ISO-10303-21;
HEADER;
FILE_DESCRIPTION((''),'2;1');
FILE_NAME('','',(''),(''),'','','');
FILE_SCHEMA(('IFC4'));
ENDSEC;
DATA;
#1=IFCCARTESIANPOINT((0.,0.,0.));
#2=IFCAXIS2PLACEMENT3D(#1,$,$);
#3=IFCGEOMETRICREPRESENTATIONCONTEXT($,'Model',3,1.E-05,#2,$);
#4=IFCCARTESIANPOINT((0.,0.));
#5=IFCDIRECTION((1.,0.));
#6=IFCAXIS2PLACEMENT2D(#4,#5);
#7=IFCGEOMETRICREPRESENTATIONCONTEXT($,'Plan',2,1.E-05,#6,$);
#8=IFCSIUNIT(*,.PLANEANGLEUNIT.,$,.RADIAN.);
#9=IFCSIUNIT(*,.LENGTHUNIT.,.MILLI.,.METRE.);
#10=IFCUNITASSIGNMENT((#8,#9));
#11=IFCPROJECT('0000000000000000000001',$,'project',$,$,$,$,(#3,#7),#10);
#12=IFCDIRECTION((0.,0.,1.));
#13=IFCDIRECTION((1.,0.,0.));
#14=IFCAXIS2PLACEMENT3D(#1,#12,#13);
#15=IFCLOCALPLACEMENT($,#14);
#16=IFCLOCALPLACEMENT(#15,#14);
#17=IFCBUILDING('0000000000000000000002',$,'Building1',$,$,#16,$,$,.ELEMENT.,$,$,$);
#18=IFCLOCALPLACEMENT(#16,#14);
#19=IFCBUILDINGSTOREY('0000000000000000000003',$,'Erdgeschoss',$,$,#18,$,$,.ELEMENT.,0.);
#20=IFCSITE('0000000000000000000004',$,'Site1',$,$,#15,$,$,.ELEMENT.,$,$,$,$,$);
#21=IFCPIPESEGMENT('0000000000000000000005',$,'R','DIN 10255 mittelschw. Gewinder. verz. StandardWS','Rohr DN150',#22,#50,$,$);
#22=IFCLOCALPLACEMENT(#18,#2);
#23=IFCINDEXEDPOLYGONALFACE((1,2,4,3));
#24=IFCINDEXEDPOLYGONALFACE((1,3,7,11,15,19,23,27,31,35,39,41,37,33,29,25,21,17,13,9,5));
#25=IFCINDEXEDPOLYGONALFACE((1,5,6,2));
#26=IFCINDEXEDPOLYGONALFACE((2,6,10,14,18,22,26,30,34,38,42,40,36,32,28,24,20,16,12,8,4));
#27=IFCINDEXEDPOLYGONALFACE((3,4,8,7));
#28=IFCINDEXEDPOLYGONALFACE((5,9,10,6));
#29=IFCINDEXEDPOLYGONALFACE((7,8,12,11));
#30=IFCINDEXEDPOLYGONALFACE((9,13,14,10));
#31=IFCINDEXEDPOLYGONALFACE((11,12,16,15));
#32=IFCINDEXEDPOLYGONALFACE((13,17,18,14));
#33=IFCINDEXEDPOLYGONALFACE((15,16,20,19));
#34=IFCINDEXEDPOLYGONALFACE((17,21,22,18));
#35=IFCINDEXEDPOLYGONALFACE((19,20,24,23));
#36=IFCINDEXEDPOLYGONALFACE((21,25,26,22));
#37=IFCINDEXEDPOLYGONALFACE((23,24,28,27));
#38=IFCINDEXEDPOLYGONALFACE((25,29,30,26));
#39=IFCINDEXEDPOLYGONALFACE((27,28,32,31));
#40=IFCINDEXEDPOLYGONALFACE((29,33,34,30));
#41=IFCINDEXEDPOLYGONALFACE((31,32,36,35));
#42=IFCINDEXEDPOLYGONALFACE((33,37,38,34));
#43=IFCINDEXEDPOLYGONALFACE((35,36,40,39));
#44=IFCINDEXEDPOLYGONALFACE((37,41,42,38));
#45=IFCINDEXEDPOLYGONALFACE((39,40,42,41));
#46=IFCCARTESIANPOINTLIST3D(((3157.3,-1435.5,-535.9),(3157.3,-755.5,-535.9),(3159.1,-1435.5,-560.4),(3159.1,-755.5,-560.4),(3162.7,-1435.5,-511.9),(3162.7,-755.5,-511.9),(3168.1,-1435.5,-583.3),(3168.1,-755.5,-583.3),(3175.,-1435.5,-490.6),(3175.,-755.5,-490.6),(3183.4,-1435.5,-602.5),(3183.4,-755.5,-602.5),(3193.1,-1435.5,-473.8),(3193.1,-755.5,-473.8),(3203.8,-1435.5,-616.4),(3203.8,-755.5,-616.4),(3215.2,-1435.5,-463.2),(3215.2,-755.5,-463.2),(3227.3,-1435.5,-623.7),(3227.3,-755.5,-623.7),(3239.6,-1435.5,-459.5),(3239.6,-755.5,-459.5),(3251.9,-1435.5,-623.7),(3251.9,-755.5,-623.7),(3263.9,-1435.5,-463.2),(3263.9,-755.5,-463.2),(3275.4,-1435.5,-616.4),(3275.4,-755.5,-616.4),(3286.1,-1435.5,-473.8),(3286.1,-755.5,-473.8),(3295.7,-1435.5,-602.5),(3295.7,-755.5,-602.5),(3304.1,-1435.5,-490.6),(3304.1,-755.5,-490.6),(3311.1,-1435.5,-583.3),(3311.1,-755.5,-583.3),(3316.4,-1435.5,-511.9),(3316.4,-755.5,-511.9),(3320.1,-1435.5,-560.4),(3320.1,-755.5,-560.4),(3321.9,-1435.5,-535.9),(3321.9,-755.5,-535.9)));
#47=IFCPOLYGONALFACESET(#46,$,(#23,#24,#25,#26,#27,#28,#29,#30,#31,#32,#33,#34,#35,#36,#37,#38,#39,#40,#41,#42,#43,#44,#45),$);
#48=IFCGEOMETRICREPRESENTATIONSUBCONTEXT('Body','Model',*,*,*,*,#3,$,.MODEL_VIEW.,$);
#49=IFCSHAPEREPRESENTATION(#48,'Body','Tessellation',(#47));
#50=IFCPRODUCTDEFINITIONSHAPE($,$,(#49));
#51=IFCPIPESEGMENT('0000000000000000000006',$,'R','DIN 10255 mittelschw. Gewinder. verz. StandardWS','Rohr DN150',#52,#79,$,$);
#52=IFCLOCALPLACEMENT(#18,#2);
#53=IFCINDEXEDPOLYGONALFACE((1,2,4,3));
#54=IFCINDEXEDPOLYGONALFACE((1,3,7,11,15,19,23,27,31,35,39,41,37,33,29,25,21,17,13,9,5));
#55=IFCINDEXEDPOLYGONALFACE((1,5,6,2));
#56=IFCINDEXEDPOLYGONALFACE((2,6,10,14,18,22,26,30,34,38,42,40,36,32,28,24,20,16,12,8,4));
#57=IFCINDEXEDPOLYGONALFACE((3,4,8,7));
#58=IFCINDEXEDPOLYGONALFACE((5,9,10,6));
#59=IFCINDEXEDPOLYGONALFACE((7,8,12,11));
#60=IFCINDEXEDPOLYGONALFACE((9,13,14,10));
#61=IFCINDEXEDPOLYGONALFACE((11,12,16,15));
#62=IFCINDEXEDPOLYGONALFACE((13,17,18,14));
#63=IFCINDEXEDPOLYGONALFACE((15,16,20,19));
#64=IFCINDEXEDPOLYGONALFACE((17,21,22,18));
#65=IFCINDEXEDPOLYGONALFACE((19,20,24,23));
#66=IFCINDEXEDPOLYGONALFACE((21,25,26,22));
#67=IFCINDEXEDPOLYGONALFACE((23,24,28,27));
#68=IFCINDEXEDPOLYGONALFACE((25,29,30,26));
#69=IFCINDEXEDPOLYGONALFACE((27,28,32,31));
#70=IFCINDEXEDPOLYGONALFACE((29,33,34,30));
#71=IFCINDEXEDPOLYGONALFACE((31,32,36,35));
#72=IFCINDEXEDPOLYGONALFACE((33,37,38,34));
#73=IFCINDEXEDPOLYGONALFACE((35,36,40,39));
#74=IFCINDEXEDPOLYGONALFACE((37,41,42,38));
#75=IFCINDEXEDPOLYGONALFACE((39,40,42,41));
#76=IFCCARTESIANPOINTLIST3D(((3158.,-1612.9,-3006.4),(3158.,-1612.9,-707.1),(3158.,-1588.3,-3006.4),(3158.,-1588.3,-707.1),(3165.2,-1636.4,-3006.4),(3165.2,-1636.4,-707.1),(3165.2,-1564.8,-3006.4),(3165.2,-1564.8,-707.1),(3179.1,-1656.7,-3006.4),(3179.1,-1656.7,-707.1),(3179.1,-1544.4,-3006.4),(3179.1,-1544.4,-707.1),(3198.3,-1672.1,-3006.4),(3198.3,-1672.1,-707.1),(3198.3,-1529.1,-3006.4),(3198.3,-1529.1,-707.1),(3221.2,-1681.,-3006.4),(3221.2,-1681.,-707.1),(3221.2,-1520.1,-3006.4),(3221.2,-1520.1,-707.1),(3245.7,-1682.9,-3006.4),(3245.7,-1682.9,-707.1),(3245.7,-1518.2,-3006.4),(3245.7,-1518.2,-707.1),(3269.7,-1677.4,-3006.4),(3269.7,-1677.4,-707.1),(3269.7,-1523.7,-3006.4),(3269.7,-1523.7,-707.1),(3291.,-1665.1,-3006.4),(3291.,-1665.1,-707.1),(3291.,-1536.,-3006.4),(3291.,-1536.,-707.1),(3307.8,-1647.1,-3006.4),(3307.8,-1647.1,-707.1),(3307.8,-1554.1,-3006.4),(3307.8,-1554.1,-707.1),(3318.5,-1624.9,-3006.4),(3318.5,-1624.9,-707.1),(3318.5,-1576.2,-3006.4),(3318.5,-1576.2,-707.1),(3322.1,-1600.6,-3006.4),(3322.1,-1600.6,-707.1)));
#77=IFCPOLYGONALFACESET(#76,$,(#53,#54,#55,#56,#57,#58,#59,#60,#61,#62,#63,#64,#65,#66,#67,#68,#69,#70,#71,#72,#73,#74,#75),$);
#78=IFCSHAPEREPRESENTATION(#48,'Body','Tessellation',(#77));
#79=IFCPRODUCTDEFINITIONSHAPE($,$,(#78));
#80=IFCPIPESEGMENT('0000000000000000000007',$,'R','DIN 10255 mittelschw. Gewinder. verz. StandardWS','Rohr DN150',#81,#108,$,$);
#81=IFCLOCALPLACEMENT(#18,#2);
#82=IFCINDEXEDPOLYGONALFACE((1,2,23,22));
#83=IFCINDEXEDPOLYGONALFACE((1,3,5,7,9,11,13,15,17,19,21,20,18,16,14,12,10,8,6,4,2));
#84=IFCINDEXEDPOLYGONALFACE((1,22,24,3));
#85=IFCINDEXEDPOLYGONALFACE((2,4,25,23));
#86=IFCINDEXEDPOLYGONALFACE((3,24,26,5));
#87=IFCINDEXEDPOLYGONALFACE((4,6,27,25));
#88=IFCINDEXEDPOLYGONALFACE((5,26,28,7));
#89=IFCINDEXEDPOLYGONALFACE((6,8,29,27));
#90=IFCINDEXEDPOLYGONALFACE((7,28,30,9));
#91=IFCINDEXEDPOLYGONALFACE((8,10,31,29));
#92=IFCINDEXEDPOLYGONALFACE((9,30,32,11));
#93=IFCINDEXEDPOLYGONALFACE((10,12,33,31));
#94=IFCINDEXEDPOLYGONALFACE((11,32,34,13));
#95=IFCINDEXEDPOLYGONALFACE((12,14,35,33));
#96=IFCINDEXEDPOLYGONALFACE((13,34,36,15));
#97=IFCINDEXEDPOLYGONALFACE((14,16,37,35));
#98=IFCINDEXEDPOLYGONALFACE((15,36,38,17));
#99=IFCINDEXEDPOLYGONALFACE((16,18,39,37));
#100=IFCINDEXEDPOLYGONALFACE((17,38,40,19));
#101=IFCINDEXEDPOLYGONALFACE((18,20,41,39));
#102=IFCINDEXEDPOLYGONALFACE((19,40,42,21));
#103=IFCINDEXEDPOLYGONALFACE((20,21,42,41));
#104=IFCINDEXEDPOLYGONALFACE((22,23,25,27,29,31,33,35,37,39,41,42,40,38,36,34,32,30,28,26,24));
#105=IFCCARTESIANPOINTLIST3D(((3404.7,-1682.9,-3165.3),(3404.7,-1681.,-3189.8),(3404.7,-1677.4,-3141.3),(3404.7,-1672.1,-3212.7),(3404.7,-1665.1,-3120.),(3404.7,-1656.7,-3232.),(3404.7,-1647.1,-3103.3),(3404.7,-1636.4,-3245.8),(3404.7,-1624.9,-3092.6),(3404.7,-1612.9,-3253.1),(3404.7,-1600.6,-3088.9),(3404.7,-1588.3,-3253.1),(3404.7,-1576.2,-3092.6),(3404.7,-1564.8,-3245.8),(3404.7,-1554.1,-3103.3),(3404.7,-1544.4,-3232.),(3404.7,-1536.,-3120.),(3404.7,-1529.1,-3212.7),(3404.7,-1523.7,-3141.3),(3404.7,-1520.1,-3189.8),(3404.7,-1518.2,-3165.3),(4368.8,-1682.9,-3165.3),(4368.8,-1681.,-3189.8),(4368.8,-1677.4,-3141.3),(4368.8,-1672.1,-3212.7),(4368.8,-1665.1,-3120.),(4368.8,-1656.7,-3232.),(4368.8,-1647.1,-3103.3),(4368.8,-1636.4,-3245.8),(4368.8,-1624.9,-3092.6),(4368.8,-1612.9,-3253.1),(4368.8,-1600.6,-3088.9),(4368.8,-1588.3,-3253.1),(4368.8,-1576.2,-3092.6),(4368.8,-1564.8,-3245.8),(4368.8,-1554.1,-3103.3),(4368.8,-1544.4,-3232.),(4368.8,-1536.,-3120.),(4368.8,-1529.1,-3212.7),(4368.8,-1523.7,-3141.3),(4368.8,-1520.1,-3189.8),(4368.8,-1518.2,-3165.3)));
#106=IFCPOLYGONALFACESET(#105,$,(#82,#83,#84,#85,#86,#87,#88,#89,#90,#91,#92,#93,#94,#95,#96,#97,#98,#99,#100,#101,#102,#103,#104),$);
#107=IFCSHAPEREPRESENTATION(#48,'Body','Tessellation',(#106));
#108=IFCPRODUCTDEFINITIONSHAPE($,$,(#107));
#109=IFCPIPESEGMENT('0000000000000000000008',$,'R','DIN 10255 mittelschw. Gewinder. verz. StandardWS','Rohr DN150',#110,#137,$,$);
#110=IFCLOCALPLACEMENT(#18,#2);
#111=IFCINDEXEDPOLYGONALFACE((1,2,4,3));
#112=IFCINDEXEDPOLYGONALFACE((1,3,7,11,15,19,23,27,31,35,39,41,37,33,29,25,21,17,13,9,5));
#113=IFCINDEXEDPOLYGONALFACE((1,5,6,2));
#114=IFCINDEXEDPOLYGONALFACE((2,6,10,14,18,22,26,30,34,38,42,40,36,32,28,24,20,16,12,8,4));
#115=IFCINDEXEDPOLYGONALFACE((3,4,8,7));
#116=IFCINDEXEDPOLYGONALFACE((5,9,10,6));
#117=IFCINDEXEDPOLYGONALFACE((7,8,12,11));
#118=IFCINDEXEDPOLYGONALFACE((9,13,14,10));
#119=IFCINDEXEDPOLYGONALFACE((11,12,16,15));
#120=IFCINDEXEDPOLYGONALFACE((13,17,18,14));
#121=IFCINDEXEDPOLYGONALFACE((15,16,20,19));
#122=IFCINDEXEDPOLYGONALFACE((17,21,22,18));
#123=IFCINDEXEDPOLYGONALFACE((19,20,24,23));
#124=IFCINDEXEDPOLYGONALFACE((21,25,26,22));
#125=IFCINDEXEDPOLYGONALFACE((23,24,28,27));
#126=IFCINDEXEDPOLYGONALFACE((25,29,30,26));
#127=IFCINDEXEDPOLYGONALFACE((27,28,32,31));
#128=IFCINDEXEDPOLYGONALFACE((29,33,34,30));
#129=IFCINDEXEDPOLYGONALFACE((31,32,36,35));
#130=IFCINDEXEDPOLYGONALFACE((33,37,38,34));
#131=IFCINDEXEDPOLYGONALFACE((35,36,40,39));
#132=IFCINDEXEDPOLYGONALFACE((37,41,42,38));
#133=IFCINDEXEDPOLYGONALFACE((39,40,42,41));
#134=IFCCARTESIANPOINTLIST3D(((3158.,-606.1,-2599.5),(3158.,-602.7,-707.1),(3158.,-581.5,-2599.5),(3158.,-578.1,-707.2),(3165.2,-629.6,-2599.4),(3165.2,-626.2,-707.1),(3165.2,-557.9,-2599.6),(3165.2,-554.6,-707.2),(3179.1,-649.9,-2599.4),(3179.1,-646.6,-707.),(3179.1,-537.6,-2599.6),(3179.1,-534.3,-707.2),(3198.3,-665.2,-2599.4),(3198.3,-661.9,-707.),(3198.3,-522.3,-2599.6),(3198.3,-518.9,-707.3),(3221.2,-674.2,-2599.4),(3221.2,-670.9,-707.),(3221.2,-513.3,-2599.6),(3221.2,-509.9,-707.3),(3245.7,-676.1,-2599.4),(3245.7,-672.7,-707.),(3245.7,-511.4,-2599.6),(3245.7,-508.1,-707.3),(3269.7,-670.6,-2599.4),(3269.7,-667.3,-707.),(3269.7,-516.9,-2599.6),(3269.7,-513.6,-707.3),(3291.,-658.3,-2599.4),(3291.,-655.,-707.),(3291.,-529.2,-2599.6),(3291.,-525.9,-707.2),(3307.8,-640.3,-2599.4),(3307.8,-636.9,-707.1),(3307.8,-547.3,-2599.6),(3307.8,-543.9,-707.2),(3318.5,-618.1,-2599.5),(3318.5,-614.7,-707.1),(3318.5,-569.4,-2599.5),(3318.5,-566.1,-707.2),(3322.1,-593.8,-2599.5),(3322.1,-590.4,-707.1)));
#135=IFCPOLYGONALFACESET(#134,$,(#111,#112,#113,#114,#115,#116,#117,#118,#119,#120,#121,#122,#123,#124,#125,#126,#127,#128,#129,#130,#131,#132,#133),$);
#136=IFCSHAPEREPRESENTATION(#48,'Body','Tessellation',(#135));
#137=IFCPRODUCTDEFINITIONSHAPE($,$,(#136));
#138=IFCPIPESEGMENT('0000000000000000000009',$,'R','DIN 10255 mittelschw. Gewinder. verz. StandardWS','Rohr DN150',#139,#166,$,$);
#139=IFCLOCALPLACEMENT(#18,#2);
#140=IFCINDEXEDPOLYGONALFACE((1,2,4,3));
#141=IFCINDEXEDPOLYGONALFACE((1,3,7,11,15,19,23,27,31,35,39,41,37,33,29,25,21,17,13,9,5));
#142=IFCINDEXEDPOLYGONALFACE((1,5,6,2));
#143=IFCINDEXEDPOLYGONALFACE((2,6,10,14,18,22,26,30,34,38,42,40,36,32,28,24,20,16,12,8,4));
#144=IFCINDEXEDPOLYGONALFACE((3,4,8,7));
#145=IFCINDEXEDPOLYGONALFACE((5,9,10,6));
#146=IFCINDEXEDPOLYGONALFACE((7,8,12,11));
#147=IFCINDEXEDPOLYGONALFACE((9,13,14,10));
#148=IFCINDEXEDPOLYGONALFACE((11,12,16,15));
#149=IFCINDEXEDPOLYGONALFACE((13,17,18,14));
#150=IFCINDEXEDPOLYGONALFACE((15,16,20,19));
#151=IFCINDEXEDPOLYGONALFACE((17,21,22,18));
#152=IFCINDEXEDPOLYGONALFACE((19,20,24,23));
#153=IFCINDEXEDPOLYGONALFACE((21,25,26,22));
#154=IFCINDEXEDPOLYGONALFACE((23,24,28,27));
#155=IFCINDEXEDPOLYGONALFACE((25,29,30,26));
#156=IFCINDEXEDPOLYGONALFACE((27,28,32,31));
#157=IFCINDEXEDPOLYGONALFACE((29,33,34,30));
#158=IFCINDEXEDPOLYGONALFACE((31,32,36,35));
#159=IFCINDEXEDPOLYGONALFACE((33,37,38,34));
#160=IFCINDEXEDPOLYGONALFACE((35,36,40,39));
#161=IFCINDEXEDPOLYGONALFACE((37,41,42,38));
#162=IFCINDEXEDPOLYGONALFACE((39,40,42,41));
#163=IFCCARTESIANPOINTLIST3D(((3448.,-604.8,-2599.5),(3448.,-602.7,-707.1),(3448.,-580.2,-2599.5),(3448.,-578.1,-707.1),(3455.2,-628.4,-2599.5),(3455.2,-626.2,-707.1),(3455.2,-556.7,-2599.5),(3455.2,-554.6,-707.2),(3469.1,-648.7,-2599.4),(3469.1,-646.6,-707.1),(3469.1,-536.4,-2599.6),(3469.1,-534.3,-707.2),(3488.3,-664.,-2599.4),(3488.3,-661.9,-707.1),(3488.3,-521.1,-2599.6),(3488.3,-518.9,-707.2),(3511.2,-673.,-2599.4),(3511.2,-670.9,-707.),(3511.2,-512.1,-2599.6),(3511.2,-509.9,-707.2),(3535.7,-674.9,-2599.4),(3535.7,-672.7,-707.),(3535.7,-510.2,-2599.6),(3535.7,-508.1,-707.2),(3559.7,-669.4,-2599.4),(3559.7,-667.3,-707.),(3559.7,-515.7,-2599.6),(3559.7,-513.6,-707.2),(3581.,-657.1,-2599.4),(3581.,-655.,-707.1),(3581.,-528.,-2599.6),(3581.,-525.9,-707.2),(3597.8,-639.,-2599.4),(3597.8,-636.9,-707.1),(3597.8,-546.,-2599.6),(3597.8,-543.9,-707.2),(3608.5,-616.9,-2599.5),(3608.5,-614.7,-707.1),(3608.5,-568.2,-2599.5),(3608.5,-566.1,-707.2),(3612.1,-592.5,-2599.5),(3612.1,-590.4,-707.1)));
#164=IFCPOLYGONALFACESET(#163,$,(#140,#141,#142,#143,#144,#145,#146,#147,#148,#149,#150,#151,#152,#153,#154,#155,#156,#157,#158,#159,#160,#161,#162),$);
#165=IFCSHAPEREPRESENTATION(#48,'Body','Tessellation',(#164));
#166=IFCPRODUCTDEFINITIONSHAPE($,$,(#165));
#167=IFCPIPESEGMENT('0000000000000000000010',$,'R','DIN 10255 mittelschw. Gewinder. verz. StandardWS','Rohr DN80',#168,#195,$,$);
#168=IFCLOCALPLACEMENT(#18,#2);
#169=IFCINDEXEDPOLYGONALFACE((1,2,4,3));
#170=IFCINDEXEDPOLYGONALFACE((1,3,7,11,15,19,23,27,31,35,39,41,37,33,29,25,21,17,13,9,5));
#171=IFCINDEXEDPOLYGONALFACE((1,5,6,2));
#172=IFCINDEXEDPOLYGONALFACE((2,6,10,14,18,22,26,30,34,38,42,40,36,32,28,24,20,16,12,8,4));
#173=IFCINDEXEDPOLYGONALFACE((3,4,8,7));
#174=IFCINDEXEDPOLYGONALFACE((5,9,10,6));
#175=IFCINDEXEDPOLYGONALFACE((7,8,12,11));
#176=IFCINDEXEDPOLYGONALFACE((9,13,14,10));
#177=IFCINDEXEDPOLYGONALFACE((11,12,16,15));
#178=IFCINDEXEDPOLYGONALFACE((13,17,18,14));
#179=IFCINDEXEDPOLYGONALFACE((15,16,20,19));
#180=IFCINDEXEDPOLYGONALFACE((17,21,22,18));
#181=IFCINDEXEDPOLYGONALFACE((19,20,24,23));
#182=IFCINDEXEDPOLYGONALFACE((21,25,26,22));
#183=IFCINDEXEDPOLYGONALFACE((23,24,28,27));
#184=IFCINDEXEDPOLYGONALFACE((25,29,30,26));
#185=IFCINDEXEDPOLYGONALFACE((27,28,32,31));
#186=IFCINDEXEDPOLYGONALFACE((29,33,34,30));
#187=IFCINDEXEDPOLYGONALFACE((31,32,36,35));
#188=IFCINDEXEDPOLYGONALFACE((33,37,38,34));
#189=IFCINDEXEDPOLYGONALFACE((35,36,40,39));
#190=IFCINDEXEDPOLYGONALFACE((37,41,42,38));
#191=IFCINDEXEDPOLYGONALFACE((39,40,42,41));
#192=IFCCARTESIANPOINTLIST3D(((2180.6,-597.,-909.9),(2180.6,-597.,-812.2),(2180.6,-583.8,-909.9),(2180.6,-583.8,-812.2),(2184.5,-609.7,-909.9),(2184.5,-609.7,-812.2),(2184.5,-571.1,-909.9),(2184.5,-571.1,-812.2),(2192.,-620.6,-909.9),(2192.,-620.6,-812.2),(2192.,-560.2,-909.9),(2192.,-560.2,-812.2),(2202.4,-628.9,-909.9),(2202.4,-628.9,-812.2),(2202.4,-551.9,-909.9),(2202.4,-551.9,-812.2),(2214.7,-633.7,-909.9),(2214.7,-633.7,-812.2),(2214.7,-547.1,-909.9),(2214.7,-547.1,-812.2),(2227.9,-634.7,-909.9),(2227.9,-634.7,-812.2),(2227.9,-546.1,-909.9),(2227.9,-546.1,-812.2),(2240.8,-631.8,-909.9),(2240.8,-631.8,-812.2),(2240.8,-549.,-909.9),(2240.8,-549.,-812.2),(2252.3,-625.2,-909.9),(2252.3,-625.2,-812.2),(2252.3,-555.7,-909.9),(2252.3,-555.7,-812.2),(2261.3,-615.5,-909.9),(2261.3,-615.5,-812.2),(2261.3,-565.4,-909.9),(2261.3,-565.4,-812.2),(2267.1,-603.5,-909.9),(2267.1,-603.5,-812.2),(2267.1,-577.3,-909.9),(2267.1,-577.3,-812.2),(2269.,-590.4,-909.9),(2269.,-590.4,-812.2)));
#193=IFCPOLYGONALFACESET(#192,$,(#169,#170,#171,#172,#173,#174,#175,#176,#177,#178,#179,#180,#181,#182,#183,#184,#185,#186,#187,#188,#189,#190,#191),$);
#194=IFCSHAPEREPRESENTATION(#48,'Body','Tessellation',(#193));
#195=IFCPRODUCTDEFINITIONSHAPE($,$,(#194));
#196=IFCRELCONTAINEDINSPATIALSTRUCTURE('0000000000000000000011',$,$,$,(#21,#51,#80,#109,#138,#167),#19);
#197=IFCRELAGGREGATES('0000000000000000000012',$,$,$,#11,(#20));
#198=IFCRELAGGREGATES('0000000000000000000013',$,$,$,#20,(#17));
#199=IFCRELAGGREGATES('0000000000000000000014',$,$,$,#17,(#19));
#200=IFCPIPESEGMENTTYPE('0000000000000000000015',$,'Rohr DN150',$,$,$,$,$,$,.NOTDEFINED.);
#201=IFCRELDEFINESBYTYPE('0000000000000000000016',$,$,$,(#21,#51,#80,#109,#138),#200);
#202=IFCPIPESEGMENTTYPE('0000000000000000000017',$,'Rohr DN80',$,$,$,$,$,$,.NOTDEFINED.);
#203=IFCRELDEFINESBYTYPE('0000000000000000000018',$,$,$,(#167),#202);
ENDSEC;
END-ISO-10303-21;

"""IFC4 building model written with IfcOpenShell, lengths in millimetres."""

from ifc_helpers import new_model, si_unit, frame, origin, origin_with_axes, origin_2d_with_axis, place, context, subcontext, project, spatial, circle, extrude, type_object, element, save


model = new_model("IFC4")

# Units and contexts
model_context = context("Model", 3, precision=1e-05, world=origin())
plan_context = context("Plan", 2, precision=1e-05, world=origin_2d_with_axis())
body_context = subcontext(model_context, "Body", "Model", "MODEL_VIEW")
ifc_project = project(units=[si_unit("PLANEANGLEUNIT", "RADIAN"), si_unit("LENGTHUNIT", "METRE", prefix="MILLI")], contexts=[model_context, plan_context])

# Site, building, storey
site_placement = place(None, origin_with_axes())
site = spatial("IfcSite", under=ifc_project, at=site_placement, Name="Site1", CompositionType="ELEMENT")
building_placement = place(site_placement, origin_with_axes())
building = spatial("IfcBuilding", under=site, at=building_placement, Name="Building1", CompositionType="ELEMENT")
storey_placement = place(building_placement, origin_with_axes())
storey = spatial("IfcBuildingStorey", under=building, at=storey_placement, Name="Erdgeschoss", CompositionType="ELEMENT", Elevation=0.0)

# Pipe segments
pipe_segment_type_1 = type_object("IfcPipeSegmentType", Name="Rohr DN150", PredefinedType="NOTDEFINED")
pipe_segment_1_placement = place(storey_placement, frame((3239.7, -1095.5, -542.0), z_axis=(0.0, 0.0, 1.0), x_axis=(1.0, 0.0, 0.0)))
element("IfcPipeSegment", 1, at=pipe_segment_1_placement, inside=storey, type_object=pipe_segment_type_1, Name="R", Description="DIN 10255 mittelschw. Gewinder. verz. StandardWS", ObjectType="Rohr DN150", context=body_context, shape_type="SolidModel", body=[
    extrude(circle(Radius=82.5, at=origin_2d_with_axis()), frame((-0.2, 340.0, 0.0), z_axis=(0.0, -1.0, 0.0), x_axis=(0.0, 0.0, 1.0)), (0.0, 0.0, 1.0), 680.0),
])
pipe_segment_2_placement = place(storey_placement, frame((3239.6, -1600.4, -1856.8), z_axis=(0.0, 0.0, 1.0), x_axis=(1.0, 0.0, 0.0)))
element("IfcPipeSegment", 2, at=pipe_segment_2_placement, inside=storey, type_object=pipe_segment_type_1, Name="R", Description="DIN 10255 mittelschw. Gewinder. verz. StandardWS", ObjectType="Rohr DN150", context=body_context, shape_type="SolidModel", body=[
    extrude(circle(Radius=82.5, at=origin_2d_with_axis()), frame((0.0, -0.2, 1149.6), z_axis=(0.0, 0.0, -1.0), x_axis=(1.0, 0.0, 0.0)), (0.0, 0.0, 1.0), 2299.2),
])
pipe_segment_3_placement = place(storey_placement, frame((3886.8, -1600.7, -3171.5), z_axis=(0.0, 0.0, 1.0), x_axis=(1.0, 0.0, 0.0)))
element("IfcPipeSegment", 3, at=pipe_segment_3_placement, inside=storey, type_object=pipe_segment_type_1, Name="R", Description="DIN 10255 mittelschw. Gewinder. verz. StandardWS", ObjectType="Rohr DN150", context=body_context, shape_type="SolidModel", body=[
    extrude(circle(Radius=82.5, at=origin_2d_with_axis()), frame((482.1, 0.1, 0.0), z_axis=(-1.0, 0.0, 0.0), x_axis=(0.0, 0.0, 1.0)), (0.0, 0.0, 1.0), 964.1),
])
pipe_segment_4_placement = place(storey_placement, frame((3239.6, -592.2, -1653.3), z_axis=(0.0, 0.0, 1.0), x_axis=(1.0, 0.0, 0.0)))
element("IfcPipeSegment", 4, at=pipe_segment_4_placement, inside=storey, type_object=pipe_segment_type_1, Name="R", Description="DIN 10255 mittelschw. Gewinder. verz. StandardWS", ObjectType="Rohr DN150", context=body_context, shape_type="SolidModel", body=[
    extrude(circle(Radius=82.5, at=origin_2d_with_axis()), frame((0.0, -1.5, -946.2), z_axis=(0.0, 0.001768, 0.999998), x_axis=(1.0, 0.0, 0.0)), (0.0, 0.0, 1.0), 1892.4),
])
pipe_segment_5_placement = place(storey_placement, frame((3529.6, -591.6, -1653.3), z_axis=(0.0, 0.0, 1.0), x_axis=(1.0, 0.0, 0.0)))
element("IfcPipeSegment", 5, at=pipe_segment_5_placement, inside=storey, type_object=pipe_segment_type_1, Name="R", Description="DIN 10255 mittelschw. Gewinder. verz. StandardWS", ObjectType="Rohr DN150", context=body_context, shape_type="SolidModel", body=[
    extrude(circle(Radius=82.5, at=origin_2d_with_axis()), frame((0.0, -0.9, -946.2), z_axis=(0.0, 0.001126, 0.999999), x_axis=(1.0, 0.0, 0.0)), (0.0, 0.0, 1.0), 1892.4),
])
pipe_segment_type_2 = type_object("IfcPipeSegmentType", Name="Rohr DN80", PredefinedType="NOTDEFINED")
pipe_segment_6_placement = place(storey_placement, frame((2224.6, -590.6, -861.0), z_axis=(0.0, 0.0, 1.0), x_axis=(1.0, 0.0, 0.0)))
element("IfcPipeSegment", 6, at=pipe_segment_6_placement, inside=storey, type_object=pipe_segment_type_2, Name="R", Description="DIN 10255 mittelschw. Gewinder. verz. StandardWS", ObjectType="Rohr DN80", context=body_context, shape_type="SolidModel", body=[
    extrude(circle(Radius=44.5, at=origin_2d_with_axis()), frame((0.0, 0.1, -48.8), z_axis=(0.0, 0.0, 1.0), x_axis=(1.0, 0.0, 0.0)), (0.0, 0.0, 1.0), 97.7),
])

save(model, "model.ifc")
